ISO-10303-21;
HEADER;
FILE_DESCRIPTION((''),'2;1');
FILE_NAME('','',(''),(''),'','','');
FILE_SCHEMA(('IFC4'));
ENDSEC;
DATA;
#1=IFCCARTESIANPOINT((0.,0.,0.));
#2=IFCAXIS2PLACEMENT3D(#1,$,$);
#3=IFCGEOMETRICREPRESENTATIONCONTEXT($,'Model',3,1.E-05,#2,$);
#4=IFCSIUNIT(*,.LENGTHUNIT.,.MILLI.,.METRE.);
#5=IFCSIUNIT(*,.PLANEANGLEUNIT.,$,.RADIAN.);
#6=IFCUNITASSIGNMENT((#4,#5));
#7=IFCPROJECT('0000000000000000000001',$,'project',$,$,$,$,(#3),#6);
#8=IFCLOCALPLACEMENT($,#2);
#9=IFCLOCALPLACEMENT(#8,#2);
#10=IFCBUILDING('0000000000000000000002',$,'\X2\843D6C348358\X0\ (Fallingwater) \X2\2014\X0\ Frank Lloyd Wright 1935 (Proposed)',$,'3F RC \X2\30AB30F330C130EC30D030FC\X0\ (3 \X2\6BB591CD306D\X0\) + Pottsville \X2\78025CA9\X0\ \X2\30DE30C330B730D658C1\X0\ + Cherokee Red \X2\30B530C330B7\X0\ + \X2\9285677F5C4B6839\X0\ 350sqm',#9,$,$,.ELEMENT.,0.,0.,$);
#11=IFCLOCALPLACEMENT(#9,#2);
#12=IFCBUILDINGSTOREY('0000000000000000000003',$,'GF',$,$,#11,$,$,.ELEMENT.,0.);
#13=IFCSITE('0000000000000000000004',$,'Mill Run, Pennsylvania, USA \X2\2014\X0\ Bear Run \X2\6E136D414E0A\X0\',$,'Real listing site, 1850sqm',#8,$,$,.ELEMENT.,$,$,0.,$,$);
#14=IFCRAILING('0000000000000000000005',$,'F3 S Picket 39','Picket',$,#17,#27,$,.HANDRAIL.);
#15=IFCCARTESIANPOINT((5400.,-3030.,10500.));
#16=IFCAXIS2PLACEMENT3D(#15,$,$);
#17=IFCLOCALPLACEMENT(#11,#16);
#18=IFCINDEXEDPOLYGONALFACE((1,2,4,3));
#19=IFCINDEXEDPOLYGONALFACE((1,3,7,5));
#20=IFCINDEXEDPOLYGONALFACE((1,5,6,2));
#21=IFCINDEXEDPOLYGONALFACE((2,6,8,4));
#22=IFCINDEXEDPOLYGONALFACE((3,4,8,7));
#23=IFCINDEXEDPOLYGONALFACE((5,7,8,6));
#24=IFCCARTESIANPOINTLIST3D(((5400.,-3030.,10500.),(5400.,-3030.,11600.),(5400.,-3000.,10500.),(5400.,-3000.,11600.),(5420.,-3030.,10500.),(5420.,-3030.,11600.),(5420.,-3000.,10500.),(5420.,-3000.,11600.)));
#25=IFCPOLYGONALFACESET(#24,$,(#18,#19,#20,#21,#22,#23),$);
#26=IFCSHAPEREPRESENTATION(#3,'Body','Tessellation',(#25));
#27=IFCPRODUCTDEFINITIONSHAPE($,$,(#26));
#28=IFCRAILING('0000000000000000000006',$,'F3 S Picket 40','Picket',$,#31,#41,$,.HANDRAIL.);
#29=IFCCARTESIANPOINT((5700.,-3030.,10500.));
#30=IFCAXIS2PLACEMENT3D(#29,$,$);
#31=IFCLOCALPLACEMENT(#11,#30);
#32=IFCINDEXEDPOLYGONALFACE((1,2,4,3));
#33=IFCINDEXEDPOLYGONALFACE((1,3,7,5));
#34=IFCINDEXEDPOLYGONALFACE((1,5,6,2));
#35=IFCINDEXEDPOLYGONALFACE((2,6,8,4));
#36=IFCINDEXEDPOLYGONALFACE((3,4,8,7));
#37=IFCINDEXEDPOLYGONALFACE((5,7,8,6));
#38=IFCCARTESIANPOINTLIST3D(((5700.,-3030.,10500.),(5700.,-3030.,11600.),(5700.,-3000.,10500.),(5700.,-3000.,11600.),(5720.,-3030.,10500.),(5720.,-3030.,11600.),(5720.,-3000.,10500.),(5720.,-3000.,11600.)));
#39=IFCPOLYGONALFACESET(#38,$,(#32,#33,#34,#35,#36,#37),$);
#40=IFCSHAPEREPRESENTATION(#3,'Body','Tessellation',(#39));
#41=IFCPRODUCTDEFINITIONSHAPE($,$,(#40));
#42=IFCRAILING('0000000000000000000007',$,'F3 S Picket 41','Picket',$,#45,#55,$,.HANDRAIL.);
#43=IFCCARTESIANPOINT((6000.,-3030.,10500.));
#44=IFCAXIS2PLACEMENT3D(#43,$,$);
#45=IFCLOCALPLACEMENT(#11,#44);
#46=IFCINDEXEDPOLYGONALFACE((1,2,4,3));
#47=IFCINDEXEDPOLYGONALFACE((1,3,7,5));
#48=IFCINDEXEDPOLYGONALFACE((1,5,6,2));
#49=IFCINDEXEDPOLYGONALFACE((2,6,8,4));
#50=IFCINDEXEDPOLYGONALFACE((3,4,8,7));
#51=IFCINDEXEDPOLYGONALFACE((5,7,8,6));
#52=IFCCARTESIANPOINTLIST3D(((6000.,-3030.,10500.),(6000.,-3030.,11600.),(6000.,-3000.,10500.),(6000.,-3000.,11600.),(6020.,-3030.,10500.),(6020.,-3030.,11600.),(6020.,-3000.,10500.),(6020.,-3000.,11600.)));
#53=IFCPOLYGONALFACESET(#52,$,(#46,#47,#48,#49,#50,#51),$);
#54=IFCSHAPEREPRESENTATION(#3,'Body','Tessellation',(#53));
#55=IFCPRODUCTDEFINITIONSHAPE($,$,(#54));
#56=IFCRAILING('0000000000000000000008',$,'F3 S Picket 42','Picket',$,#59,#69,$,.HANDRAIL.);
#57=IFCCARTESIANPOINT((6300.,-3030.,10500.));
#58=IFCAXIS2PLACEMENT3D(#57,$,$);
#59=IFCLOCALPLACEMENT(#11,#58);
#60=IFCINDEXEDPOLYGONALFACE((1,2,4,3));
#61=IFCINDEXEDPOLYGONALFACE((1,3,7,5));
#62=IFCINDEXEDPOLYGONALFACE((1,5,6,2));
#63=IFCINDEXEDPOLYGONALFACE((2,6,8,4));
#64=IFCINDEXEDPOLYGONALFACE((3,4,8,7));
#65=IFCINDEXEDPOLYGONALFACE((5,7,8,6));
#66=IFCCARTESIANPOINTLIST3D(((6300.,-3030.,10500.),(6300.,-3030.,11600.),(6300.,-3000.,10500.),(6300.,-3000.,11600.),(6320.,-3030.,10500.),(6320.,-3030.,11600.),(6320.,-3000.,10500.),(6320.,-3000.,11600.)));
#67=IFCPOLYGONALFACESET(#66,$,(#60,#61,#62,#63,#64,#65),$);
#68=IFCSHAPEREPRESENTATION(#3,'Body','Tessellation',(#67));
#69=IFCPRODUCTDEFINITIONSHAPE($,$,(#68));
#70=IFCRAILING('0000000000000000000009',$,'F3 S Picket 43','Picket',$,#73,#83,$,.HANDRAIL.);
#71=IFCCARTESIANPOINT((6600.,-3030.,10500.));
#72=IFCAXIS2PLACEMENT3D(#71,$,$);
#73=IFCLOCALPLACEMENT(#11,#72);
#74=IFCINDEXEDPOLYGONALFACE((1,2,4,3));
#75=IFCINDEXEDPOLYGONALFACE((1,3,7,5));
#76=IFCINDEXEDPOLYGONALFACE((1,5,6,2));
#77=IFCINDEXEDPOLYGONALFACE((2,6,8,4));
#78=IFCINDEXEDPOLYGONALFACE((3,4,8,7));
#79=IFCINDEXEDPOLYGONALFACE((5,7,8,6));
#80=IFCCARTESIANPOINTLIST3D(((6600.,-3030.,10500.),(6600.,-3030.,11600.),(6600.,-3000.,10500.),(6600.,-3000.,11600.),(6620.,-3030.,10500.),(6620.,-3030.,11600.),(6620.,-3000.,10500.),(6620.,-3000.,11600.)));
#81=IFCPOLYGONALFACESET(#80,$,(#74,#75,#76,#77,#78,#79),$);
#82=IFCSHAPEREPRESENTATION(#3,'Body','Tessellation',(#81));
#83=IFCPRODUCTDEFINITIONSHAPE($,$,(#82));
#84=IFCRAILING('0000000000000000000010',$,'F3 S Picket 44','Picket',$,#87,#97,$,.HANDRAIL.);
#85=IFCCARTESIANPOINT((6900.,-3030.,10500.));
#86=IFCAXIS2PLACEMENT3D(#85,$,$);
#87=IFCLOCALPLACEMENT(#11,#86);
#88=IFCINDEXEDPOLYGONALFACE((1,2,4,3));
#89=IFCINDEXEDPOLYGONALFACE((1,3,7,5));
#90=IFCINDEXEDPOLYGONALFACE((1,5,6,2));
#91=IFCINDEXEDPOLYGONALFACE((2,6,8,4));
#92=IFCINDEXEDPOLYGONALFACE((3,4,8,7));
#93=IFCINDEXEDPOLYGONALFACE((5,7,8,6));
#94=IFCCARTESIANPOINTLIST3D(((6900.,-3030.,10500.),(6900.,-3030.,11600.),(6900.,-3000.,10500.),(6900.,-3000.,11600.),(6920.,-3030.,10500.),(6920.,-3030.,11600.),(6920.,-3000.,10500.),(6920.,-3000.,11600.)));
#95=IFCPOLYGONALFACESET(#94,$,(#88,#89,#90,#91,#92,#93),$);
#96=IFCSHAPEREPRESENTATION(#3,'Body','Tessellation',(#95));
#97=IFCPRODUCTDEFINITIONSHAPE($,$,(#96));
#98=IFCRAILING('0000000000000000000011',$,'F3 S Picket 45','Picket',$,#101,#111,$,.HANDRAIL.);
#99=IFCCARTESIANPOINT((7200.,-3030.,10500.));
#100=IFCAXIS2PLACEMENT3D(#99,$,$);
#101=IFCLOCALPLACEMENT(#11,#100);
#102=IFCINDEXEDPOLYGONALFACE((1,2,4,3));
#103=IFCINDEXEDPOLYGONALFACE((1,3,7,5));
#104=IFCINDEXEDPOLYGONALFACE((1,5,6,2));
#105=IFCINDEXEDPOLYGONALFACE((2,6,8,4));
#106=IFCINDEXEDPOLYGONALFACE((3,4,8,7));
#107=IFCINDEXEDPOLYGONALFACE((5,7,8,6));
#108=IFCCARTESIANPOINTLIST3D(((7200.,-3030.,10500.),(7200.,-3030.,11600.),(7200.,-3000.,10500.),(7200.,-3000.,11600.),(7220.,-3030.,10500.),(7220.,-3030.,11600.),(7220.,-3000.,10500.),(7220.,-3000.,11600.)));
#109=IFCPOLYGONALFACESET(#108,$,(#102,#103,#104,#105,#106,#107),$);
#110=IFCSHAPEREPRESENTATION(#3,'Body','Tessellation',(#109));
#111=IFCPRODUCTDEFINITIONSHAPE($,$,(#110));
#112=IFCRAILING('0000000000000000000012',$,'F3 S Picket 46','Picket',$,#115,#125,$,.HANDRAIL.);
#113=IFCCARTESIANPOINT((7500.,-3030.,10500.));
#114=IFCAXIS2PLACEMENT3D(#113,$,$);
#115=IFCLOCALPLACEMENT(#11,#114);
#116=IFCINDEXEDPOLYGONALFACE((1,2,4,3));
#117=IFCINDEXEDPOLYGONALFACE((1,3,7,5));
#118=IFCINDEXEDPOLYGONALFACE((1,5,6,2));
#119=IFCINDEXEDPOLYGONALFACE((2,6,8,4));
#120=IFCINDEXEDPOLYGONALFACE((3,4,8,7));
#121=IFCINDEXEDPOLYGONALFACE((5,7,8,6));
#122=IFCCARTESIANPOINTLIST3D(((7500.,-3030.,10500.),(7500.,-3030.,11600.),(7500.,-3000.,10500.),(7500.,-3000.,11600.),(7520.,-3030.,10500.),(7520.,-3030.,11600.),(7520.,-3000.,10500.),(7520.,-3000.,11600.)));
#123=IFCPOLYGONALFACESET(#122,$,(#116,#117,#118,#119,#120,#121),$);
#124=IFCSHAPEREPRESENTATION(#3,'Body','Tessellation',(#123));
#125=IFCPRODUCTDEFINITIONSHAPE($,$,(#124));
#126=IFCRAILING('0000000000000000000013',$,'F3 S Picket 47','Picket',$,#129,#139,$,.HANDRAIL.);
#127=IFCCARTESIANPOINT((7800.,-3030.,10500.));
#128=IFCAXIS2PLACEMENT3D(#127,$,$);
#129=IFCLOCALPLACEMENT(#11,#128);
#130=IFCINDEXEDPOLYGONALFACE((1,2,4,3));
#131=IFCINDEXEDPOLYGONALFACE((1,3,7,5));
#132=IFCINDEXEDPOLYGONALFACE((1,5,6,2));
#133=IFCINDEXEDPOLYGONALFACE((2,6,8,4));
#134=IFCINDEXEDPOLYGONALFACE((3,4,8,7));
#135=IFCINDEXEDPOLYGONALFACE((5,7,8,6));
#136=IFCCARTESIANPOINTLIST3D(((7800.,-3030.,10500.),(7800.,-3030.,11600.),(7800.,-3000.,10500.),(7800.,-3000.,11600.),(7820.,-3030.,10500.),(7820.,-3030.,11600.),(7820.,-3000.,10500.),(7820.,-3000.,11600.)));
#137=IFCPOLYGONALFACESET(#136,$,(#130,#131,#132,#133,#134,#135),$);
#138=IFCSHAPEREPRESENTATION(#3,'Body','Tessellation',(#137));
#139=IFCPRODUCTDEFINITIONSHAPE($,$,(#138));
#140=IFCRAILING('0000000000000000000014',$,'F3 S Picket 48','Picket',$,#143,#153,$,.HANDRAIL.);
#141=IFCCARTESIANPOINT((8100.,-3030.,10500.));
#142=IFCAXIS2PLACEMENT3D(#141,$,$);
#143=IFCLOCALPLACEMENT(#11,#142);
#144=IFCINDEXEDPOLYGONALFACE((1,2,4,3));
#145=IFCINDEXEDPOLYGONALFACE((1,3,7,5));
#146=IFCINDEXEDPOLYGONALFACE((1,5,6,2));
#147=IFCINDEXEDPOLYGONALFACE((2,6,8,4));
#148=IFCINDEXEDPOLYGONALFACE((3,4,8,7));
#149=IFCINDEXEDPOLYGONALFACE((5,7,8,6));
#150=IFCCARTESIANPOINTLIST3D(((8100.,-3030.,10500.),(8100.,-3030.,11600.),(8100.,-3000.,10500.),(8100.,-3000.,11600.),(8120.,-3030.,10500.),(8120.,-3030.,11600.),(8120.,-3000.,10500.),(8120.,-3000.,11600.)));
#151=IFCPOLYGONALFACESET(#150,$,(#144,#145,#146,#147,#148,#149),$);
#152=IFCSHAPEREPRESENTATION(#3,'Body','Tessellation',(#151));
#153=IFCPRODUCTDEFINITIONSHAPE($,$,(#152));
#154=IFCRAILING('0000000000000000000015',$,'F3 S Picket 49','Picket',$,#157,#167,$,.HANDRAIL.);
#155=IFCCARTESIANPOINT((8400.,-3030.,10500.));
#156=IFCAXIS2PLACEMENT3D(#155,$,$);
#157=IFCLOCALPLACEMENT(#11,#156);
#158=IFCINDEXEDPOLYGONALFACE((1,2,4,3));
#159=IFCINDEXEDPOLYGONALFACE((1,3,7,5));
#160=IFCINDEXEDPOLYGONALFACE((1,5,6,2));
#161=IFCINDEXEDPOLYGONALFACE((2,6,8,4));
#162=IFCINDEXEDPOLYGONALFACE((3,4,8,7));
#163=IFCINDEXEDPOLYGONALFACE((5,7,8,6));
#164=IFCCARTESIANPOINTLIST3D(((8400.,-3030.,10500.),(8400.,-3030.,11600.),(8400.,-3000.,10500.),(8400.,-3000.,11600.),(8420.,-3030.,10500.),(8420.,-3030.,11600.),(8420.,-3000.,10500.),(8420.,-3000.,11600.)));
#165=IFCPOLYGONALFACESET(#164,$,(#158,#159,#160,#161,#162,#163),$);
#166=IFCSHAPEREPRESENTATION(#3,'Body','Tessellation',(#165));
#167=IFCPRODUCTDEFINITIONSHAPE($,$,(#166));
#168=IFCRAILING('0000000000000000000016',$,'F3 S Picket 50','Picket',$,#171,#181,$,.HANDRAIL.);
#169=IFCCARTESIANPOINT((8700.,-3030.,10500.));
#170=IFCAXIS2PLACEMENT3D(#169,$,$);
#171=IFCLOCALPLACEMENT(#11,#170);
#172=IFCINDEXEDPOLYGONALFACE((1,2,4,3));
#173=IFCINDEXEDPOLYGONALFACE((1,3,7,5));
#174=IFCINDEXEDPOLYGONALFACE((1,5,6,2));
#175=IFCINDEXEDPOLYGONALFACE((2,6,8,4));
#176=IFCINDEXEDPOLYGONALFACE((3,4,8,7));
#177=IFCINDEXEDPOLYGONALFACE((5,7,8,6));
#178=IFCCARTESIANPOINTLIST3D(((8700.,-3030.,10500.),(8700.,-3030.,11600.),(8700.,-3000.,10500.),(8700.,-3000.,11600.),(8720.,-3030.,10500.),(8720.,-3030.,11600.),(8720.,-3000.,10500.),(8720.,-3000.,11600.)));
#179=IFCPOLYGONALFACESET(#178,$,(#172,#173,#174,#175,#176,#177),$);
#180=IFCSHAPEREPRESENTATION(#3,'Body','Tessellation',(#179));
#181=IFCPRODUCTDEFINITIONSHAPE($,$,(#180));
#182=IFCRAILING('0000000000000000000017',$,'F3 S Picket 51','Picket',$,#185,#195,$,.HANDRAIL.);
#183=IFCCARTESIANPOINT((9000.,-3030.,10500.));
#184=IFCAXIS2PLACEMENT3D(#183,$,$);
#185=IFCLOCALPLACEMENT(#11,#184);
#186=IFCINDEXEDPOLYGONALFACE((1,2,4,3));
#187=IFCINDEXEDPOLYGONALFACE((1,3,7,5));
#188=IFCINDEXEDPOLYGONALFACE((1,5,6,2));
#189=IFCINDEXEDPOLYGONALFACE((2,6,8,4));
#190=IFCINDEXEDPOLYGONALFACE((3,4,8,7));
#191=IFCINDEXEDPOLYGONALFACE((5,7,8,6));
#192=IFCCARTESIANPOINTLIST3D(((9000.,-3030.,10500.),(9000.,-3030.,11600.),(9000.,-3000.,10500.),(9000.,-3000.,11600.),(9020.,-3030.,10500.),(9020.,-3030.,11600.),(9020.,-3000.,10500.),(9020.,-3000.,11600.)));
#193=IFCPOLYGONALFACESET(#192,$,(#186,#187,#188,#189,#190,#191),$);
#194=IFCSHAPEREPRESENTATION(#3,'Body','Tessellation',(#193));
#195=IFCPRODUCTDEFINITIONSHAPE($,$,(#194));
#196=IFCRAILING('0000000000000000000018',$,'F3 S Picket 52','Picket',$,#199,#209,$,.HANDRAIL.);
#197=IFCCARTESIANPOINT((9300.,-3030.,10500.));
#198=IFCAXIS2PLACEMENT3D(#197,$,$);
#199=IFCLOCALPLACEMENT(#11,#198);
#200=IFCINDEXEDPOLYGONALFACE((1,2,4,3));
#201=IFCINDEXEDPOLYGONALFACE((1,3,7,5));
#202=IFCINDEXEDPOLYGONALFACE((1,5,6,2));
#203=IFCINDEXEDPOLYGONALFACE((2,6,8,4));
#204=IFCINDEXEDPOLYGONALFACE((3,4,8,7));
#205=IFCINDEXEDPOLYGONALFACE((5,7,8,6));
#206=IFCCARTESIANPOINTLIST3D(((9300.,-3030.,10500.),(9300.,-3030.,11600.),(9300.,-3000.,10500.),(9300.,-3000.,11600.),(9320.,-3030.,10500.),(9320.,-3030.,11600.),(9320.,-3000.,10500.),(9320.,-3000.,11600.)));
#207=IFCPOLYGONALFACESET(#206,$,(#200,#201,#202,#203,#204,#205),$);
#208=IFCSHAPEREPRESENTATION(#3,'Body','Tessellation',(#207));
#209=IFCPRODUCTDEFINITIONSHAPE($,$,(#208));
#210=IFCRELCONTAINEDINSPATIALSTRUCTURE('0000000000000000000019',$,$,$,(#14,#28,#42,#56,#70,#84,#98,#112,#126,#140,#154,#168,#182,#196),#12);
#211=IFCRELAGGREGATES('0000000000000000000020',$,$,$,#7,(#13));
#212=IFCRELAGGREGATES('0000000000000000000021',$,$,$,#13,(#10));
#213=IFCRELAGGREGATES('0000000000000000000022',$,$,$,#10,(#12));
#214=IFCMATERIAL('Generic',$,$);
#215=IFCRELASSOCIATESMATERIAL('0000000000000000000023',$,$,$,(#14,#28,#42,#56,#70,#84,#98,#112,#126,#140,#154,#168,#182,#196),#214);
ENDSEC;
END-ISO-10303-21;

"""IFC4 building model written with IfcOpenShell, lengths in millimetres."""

from ifc_helpers import new_model, si_unit, frame, frame_2d, origin, place, context, project, spatial, rectangle, extrude, material, element, save


model = new_model("IFC4")

# Units and contexts
model_context = context("Model", 3, precision=1e-05, world=origin())
ifc_project = project(units=[si_unit("LENGTHUNIT", "METRE", prefix="MILLI"), si_unit("PLANEANGLEUNIT", "RADIAN")], contexts=[model_context])

# Site, building, storey
site_placement = place(None, origin())
site = spatial("IfcSite", under=ifc_project, at=site_placement, Name="Mill Run, Pennsylvania, USA — Bear Run 渓流上", ObjectType="Real listing site, 1850sqm", CompositionType="ELEMENT", RefElevation=0.0)
building_placement = place(site_placement, origin())
building = spatial("IfcBuilding", under=site, at=building_placement, Name="落水荘 (Fallingwater) — Frank Lloyd Wright 1935 (Proposed)", ObjectType="3F RC カンチレバー (3 段重ね) + Pottsville 砂岩 マッシブ壁 + Cherokee Red サッシ + 銅板屋根 350sqm", CompositionType="ELEMENT", ElevationOfRefHeight=0.0, ElevationOfTerrain=0.0)
storey_placement = place(building_placement, origin())
storey = spatial("IfcBuildingStorey", under=building, at=storey_placement, Name="GF", CompositionType="ELEMENT", Elevation=0.0)

# Railings
ifc_material_1 = material(Name="Generic")
railing_1_placement = place(storey_placement, frame((5400.0, -3030.0, 10500.0)))
element("IfcRailing", 1, at=railing_1_placement, inside=storey, material=ifc_material_1, Name="F3 S Picket 39", Description="Picket", PredefinedType="HANDRAIL", context=model_context, shape_type="SweptSolid", body=[
    extrude(rectangle(XDim=20.0, YDim=30.0, at=frame_2d((10.0, 15.0))), frame((5400.0, -3030.0, 10500.0)), (0.0, 0.0, 1.0), 1100.0),
])
railing_2_placement = place(storey_placement, frame((5700.0, -3030.0, 10500.0)))
element("IfcRailing", 2, at=railing_2_placement, inside=storey, material=ifc_material_1, Name="F3 S Picket 40", Description="Picket", PredefinedType="HANDRAIL", context=model_context, shape_type="SweptSolid", body=[
    extrude(rectangle(XDim=20.0, YDim=30.0, at=frame_2d((10.0, 15.0))), frame((5700.0, -3030.0, 10500.0)), (0.0, 0.0, 1.0), 1100.0),
])
railing_3_placement = place(storey_placement, frame((6000.0, -3030.0, 10500.0)))
element("IfcRailing", 3, at=railing_3_placement, inside=storey, material=ifc_material_1, Name="F3 S Picket 41", Description="Picket", PredefinedType="HANDRAIL", context=model_context, shape_type="SweptSolid", body=[
    extrude(rectangle(XDim=20.0, YDim=30.0, at=frame_2d((10.0, 15.0))), frame((6000.0, -3030.0, 10500.0)), (0.0, 0.0, 1.0), 1100.0),
])
railing_4_placement = place(storey_placement, frame((6300.0, -3030.0, 10500.0)))
element("IfcRailing", 4, at=railing_4_placement, inside=storey, material=ifc_material_1, Name="F3 S Picket 42", Description="Picket", PredefinedType="HANDRAIL", context=model_context, shape_type="SweptSolid", body=[
    extrude(rectangle(XDim=20.0, YDim=30.0, at=frame_2d((10.0, 15.0))), frame((6300.0, -3030.0, 10500.0)), (0.0, 0.0, 1.0), 1100.0),
])
railing_5_placement = place(storey_placement, frame((6600.0, -3030.0, 10500.0)))
element("IfcRailing", 5, at=railing_5_placement, inside=storey, material=ifc_material_1, Name="F3 S Picket 43", Description="Picket", PredefinedType="HANDRAIL", context=model_context, shape_type="SweptSolid", body=[
    extrude(rectangle(XDim=20.0, YDim=30.0, at=frame_2d((10.0, 15.0))), frame((6600.0, -3030.0, 10500.0)), (0.0, 0.0, 1.0), 1100.0),
])
railing_6_placement = place(storey_placement, frame((6900.0, -3030.0, 10500.0)))
element("IfcRailing", 6, at=railing_6_placement, inside=storey, material=ifc_material_1, Name="F3 S Picket 44", Description="Picket", PredefinedType="HANDRAIL", context=model_context, shape_type="SweptSolid", body=[
    extrude(rectangle(XDim=20.0, YDim=30.0, at=frame_2d((10.0, 15.0))), frame((6900.0, -3030.0, 10500.0)), (0.0, 0.0, 1.0), 1100.0),
])
railing_7_placement = place(storey_placement, frame((7200.0, -3030.0, 10500.0)))
element("IfcRailing", 7, at=railing_7_placement, inside=storey, material=ifc_material_1, Name="F3 S Picket 45", Description="Picket", PredefinedType="HANDRAIL", context=model_context, shape_type="SweptSolid", body=[
    extrude(rectangle(XDim=20.0, YDim=30.0, at=frame_2d((10.0, 15.0))), frame((7200.0, -3030.0, 10500.0)), (0.0, 0.0, 1.0), 1100.0),
])
railing_8_placement = place(storey_placement, frame((7500.0, -3030.0, 10500.0)))
element("IfcRailing", 8, at=railing_8_placement, inside=storey, material=ifc_material_1, Name="F3 S Picket 46", Description="Picket", PredefinedType="HANDRAIL", context=model_context, shape_type="SweptSolid", body=[
    extrude(rectangle(XDim=20.0, YDim=30.0, at=frame_2d((10.0, 15.0))), frame((7500.0, -3030.0, 10500.0)), (0.0, 0.0, 1.0), 1100.0),
])
railing_9_placement = place(storey_placement, frame((7800.0, -3030.0, 10500.0)))
element("IfcRailing", 9, at=railing_9_placement, inside=storey, material=ifc_material_1, Name="F3 S Picket 47", Description="Picket", PredefinedType="HANDRAIL", context=model_context, shape_type="SweptSolid", body=[
    extrude(rectangle(XDim=20.0, YDim=30.0, at=frame_2d((10.0, 15.0))), frame((7800.0, -3030.0, 10500.0)), (0.0, 0.0, 1.0), 1100.0),
])
railing_10_placement = place(storey_placement, frame((8100.0, -3030.0, 10500.0)))
element("IfcRailing", 10, at=railing_10_placement, inside=storey, material=ifc_material_1, Name="F3 S Picket 48", Description="Picket", PredefinedType="HANDRAIL", context=model_context, shape_type="SweptSolid", body=[
    extrude(rectangle(XDim=20.0, YDim=30.0, at=frame_2d((10.0, 15.0))), frame((8100.0, -3030.0, 10500.0)), (0.0, 0.0, 1.0), 1100.0),
])
railing_11_placement = place(storey_placement, frame((8400.0, -3030.0, 10500.0)))
element("IfcRailing", 11, at=railing_11_placement, inside=storey, material=ifc_material_1, Name="F3 S Picket 49", Description="Picket", PredefinedType="HANDRAIL", context=model_context, shape_type="SweptSolid", body=[
    extrude(rectangle(XDim=20.0, YDim=30.0, at=frame_2d((10.0, 15.0))), frame((8400.0, -3030.0, 10500.0)), (0.0, 0.0, 1.0), 1100.0),
])
railing_12_placement = place(storey_placement, frame((8700.0, -3030.0, 10500.0)))
element("IfcRailing", 12, at=railing_12_placement, inside=storey, material=ifc_material_1, Name="F3 S Picket 50", Description="Picket", PredefinedType="HANDRAIL", context=model_context, shape_type="SweptSolid", body=[
    extrude(rectangle(XDim=20.0, YDim=30.0, at=frame_2d((10.0, 15.0))), frame((8700.0, -3030.0, 10500.0)), (0.0, 0.0, 1.0), 1100.0),
])
railing_13_placement = place(storey_placement, frame((9000.0, -3030.0, 10500.0)))
element("IfcRailing", 13, at=railing_13_placement, inside=storey, material=ifc_material_1, Name="F3 S Picket 51", Description="Picket", PredefinedType="HANDRAIL", context=model_context, shape_type="SweptSolid", body=[
    extrude(rectangle(XDim=20.0, YDim=30.0, at=frame_2d((10.0, 15.0))), frame((9000.0, -3030.0, 10500.0)), (0.0, 0.0, 1.0), 1100.0),
])
railing_14_placement = place(storey_placement, frame((9300.0, -3030.0, 10500.0)))
element("IfcRailing", 14, at=railing_14_placement, inside=storey, material=ifc_material_1, Name="F3 S Picket 52", Description="Picket", PredefinedType="HANDRAIL", context=model_context, shape_type="SweptSolid", body=[
    extrude(rectangle(XDim=20.0, YDim=30.0, at=frame_2d((10.0, 15.0))), frame((9300.0, -3030.0, 10500.0)), (0.0, 0.0, 1.0), 1100.0),
])

save(model, "model.ifc")
